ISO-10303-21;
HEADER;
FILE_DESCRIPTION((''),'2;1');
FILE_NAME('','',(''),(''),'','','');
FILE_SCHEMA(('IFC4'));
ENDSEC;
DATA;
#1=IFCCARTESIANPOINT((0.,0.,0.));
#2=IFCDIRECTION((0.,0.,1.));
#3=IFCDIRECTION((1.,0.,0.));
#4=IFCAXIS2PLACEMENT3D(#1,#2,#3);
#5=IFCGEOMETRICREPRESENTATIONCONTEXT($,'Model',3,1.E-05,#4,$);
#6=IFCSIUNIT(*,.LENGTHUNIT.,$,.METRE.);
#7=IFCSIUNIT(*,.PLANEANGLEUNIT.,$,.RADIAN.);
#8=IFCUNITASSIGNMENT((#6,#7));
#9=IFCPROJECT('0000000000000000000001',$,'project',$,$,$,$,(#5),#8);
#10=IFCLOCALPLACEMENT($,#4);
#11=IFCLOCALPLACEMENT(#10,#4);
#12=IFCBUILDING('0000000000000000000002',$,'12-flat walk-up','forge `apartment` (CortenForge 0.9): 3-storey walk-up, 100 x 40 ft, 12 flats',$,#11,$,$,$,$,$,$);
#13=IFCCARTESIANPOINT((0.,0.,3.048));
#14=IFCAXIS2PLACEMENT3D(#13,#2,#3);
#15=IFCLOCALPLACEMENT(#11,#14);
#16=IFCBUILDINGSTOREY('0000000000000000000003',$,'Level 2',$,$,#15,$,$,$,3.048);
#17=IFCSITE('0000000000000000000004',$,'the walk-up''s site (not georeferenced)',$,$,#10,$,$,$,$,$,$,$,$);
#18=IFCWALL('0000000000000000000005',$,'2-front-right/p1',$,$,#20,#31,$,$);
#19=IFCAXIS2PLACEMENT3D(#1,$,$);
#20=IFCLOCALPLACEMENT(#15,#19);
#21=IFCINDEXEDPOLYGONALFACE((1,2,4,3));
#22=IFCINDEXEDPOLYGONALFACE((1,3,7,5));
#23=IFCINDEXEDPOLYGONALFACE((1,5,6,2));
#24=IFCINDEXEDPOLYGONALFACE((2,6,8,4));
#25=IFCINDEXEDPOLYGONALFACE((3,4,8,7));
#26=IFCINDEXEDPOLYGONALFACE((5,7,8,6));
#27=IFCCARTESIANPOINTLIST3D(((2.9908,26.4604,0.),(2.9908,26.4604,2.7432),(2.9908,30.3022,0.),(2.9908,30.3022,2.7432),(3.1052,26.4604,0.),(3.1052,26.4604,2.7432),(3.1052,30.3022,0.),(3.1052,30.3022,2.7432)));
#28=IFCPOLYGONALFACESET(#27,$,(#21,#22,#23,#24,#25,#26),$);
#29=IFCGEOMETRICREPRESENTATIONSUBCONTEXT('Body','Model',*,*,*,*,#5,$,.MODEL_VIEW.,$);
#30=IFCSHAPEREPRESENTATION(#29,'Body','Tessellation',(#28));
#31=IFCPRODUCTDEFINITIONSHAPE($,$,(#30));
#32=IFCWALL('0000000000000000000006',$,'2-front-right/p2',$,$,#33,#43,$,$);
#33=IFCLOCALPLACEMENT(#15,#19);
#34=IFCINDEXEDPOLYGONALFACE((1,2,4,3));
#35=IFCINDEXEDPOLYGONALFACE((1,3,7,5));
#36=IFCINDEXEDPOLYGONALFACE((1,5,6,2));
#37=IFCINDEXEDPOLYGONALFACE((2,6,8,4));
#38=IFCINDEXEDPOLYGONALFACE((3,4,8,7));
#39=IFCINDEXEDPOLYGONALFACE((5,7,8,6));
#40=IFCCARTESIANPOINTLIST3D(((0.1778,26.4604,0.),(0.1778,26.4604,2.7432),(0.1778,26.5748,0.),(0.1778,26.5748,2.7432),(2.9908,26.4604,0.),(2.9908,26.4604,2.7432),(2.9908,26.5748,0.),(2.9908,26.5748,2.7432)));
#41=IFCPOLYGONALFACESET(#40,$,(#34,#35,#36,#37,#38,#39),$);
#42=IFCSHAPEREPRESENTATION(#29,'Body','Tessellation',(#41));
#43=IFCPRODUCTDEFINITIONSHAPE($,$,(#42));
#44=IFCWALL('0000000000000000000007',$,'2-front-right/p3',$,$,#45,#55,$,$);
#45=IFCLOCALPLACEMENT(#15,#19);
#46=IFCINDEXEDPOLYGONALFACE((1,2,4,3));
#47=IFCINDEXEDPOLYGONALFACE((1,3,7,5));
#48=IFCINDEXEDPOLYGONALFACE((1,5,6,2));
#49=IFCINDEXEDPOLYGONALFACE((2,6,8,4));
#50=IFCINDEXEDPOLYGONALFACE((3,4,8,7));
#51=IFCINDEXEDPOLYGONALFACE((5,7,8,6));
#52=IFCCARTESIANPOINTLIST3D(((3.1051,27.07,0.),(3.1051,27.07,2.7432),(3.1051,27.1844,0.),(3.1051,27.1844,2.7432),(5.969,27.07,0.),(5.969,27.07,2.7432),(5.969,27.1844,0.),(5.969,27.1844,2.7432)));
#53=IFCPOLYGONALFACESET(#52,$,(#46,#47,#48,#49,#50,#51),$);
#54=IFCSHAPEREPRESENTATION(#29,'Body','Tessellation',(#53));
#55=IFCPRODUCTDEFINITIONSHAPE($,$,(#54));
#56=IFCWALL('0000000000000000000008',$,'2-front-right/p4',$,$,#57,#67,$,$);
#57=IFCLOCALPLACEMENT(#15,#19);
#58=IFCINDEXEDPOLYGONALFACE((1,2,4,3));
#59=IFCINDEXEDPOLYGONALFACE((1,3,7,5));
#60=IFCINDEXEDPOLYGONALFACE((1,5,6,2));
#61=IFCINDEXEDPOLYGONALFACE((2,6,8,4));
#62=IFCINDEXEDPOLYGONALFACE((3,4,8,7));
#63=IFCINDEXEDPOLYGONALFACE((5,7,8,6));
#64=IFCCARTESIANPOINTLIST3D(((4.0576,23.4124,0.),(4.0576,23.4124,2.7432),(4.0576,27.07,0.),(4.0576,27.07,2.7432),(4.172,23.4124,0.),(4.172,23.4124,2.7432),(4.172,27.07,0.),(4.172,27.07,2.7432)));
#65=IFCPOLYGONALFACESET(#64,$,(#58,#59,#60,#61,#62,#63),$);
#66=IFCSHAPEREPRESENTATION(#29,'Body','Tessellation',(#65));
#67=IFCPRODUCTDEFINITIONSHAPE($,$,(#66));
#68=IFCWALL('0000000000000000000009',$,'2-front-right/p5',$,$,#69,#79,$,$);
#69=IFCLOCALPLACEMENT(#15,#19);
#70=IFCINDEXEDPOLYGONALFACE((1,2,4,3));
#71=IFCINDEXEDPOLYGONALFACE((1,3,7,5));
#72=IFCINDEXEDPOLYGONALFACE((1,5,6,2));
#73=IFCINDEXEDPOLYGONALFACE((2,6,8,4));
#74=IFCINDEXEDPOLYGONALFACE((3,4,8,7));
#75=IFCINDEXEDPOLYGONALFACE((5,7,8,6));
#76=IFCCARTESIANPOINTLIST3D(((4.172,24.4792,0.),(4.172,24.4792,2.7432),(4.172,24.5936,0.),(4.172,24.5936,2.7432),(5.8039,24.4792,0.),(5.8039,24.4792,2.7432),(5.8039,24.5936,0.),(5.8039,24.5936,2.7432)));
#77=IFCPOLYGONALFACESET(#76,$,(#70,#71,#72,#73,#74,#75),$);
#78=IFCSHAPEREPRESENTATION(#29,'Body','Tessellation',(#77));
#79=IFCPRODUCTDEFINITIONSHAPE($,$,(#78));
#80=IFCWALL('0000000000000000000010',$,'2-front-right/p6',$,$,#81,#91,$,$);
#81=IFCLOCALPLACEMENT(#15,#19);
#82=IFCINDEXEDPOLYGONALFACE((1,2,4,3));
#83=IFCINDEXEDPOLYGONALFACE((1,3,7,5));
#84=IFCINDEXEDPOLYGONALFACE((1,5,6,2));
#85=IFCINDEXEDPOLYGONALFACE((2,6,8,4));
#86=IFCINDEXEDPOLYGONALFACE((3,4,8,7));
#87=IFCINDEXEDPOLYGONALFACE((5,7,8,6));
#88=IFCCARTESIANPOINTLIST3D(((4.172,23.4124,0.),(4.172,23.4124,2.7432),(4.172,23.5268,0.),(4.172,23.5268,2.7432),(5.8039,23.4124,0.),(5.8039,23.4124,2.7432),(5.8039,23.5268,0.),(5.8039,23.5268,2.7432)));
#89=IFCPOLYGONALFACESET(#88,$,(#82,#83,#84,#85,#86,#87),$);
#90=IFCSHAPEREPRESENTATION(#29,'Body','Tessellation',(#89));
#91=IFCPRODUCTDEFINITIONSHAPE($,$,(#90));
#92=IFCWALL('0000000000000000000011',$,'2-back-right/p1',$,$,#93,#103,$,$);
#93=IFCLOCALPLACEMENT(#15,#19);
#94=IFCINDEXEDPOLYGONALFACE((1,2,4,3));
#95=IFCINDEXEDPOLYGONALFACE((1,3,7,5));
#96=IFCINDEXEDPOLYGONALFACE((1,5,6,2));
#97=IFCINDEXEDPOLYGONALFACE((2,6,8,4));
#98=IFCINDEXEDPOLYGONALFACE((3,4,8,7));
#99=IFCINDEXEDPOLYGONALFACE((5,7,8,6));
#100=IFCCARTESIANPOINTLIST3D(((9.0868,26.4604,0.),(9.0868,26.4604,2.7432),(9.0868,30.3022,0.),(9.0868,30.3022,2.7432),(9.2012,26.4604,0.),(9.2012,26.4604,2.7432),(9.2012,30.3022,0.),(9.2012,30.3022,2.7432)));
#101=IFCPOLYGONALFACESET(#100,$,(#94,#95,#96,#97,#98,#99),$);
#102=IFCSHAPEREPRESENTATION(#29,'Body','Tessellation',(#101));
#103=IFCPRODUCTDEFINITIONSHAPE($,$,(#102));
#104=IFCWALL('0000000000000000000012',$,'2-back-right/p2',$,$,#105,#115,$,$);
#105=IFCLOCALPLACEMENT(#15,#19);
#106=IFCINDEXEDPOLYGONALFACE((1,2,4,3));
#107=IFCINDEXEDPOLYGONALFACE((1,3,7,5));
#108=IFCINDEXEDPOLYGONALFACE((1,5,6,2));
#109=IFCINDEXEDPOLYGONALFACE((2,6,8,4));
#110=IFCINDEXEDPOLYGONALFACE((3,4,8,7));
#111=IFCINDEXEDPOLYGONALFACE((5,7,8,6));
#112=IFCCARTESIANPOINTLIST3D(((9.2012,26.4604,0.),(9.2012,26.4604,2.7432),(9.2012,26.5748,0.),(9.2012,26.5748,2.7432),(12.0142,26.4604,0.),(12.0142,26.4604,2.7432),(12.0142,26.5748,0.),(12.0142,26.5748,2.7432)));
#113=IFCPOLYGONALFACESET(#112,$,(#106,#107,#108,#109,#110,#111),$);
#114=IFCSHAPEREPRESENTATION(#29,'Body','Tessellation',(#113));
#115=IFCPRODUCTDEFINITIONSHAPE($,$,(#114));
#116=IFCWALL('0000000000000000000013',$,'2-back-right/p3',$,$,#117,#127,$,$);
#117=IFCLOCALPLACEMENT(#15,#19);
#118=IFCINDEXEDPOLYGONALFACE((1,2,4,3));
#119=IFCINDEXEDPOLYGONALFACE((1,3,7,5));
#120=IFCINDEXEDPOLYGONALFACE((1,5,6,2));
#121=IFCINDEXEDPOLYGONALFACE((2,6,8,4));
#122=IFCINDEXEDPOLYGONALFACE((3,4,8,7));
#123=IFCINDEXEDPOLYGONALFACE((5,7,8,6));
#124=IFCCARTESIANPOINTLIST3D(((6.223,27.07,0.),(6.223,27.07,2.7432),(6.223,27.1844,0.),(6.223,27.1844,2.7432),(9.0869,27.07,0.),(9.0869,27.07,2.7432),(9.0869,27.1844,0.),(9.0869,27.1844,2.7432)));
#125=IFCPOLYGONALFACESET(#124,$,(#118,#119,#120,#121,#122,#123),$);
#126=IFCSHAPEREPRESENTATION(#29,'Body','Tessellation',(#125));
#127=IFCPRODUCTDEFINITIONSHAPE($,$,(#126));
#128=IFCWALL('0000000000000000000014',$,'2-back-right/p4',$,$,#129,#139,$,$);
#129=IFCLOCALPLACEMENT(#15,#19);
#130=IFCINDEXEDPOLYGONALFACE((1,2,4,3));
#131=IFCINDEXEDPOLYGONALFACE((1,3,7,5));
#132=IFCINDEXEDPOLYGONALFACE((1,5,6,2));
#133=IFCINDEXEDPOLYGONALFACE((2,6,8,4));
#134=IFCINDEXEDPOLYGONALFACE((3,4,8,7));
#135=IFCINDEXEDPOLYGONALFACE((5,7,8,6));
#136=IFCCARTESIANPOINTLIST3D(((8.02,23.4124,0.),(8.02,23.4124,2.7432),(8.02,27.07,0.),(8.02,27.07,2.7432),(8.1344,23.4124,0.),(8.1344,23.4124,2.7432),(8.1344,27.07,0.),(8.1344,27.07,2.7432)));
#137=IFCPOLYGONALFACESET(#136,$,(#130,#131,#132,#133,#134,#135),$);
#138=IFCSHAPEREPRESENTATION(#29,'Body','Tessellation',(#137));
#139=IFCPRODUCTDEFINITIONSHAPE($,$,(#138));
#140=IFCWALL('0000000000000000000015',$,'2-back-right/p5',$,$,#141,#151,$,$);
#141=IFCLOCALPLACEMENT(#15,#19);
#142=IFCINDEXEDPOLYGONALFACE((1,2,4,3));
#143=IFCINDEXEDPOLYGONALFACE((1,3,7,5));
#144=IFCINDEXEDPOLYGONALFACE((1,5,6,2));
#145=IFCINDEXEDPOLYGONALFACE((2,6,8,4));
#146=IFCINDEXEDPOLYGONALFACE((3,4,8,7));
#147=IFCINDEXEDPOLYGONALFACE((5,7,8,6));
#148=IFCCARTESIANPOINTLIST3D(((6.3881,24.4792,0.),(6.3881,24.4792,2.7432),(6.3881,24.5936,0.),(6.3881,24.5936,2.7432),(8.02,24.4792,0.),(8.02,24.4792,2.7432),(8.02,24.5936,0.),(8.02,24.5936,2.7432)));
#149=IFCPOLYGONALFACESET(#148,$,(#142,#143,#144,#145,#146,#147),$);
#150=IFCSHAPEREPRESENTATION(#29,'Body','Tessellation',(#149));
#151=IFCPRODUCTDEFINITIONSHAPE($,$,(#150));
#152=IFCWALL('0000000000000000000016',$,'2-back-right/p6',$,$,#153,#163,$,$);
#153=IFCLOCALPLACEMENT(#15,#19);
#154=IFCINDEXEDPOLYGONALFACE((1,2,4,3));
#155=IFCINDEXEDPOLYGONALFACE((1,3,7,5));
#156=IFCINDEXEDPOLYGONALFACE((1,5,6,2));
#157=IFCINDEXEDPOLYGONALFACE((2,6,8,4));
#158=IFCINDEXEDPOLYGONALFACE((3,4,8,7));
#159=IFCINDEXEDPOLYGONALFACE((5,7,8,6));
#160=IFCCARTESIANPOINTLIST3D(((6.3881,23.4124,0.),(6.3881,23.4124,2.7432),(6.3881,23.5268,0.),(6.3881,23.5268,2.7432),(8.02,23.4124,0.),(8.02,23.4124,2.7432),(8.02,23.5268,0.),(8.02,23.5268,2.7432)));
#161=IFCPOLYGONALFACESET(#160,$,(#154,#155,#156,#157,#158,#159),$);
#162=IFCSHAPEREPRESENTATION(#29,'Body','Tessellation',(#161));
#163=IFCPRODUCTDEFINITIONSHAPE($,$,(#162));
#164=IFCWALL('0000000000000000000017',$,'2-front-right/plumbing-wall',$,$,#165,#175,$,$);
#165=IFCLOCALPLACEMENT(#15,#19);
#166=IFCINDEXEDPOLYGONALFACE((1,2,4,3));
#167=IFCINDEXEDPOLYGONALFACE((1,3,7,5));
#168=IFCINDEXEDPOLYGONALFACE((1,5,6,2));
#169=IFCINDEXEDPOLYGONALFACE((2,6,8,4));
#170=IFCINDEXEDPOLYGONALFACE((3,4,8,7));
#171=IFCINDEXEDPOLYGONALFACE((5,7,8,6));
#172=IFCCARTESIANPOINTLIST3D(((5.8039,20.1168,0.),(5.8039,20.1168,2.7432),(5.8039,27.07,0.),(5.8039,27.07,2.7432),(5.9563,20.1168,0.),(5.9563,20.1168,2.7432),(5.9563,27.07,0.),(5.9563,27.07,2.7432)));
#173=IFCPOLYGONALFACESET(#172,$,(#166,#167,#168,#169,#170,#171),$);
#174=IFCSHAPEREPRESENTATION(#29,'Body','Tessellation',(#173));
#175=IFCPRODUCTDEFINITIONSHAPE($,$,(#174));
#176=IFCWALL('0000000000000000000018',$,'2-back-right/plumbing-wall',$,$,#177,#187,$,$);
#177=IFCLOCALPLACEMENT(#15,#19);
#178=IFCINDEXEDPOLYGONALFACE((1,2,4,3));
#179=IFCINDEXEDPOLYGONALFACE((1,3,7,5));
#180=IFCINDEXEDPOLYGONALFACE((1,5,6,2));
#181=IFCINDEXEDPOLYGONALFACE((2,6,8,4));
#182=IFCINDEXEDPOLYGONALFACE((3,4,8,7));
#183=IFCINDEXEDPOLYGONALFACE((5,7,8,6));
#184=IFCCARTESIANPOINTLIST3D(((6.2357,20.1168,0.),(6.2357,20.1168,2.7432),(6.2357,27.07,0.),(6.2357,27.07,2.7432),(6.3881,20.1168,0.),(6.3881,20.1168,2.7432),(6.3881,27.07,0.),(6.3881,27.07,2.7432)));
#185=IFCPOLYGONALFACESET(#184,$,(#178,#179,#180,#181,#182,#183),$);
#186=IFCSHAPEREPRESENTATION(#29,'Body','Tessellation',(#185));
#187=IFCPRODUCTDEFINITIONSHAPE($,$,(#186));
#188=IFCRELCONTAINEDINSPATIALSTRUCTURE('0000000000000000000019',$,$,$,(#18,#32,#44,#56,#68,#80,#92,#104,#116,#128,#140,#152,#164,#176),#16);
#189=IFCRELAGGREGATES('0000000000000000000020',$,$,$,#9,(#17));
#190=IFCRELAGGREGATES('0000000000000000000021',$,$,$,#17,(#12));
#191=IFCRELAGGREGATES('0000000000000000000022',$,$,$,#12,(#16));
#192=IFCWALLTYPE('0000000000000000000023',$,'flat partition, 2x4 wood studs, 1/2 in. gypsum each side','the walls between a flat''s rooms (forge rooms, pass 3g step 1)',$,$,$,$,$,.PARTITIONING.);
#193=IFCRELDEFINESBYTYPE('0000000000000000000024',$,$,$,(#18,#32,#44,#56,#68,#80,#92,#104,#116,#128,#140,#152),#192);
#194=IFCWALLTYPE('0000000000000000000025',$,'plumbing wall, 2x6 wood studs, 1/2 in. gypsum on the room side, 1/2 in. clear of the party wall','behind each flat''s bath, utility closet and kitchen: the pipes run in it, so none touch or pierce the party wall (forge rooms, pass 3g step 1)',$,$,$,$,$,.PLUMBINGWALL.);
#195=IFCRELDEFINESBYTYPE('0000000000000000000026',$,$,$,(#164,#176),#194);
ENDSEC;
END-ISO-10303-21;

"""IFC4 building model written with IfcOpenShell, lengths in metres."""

from ifc_helpers import new_model, si_unit, frame, frame_2d, origin, origin_with_axes, place, context, subcontext, project, spatial, rectangle, extrude, type_object, element, save


model = new_model("IFC4")

# Units and contexts
model_context = context("Model", 3, precision=1e-05, world=origin_with_axes())
body_context = subcontext(model_context, "Body", "Model", "MODEL_VIEW")
ifc_project = project(units=[si_unit("LENGTHUNIT", "METRE"), si_unit("PLANEANGLEUNIT", "RADIAN")], contexts=[model_context])

# Site, building, storey
site_placement = place(None, origin_with_axes())
site = spatial("IfcSite", under=ifc_project, at=site_placement, Name="the walk-up's site (not georeferenced)")
building_placement = place(site_placement, origin_with_axes())
building = spatial("IfcBuilding", under=site, at=building_placement, Name="12-flat walk-up", Description="forge `apartment` (CortenForge 0.9): 3-storey walk-up, 100 x 40 ft, 12 flats")
storey_placement = place(building_placement, frame((0.0, 0.0, 3.048), z_axis=(0.0, 0.0, 1.0), x_axis=(1.0, 0.0, 0.0)))
storey = spatial("IfcBuildingStorey", under=building, at=storey_placement, Name="Level 2", Elevation=3.048)

# Walls
wall_type_1 = type_object("IfcWallType", Name="flat partition, 2x4 wood studs, 1/2 in. gypsum each side", Description="the walls between a flat's rooms (forge rooms, pass 3g step 1)", PredefinedType="PARTITIONING")
wall_1_placement = place(storey_placement, frame((2.9909, 26.4605, 0.0), z_axis=(0.0, 0.0, 1.0), x_axis=(1.0, 0.0, 0.0)))
element("IfcWall", 1, at=wall_1_placement, inside=storey, type_object=wall_type_1, Name="2-front-right/p1", context=body_context, shape_type="SweptSolid", body=[
    extrude(rectangle(XDim=0.1143, YDim=3.8417, at=frame_2d((0.0572, 1.9209))), origin(), (0.0, 0.0, 1.0), 2.7432),
])
wall_2_placement = place(storey_placement, frame((0.1778, 26.4605, 0.0), z_axis=(0.0, 0.0, 1.0), x_axis=(1.0, 0.0, 0.0)))
element("IfcWall", 2, at=wall_2_placement, inside=storey, type_object=wall_type_1, Name="2-front-right/p2", context=body_context, shape_type="SweptSolid", body=[
    extrude(rectangle(XDim=2.8131, YDim=0.1143, at=frame_2d((1.4065, 0.0572))), origin(), (0.0, 0.0, 1.0), 2.7432),
])
wall_3_placement = place(storey_placement, frame((3.1051, 27.07, 0.0), z_axis=(0.0, 0.0, 1.0), x_axis=(1.0, 0.0, 0.0)))
element("IfcWall", 3, at=wall_3_placement, inside=storey, type_object=wall_type_1, Name="2-front-right/p3", context=body_context, shape_type="SweptSolid", body=[
    extrude(rectangle(XDim=2.8639, YDim=0.1143, at=frame_2d((1.4319, 0.0572))), origin(), (0.0, 0.0, 1.0), 2.7432),
])
wall_4_placement = place(storey_placement, frame((4.0576, 23.4124, 0.0), z_axis=(0.0, 0.0, 1.0), x_axis=(1.0, 0.0, 0.0)))
element("IfcWall", 4, at=wall_4_placement, inside=storey, type_object=wall_type_1, Name="2-front-right/p4", context=body_context, shape_type="SweptSolid", body=[
    extrude(rectangle(XDim=0.1143, YDim=3.6576, at=frame_2d((0.0572, 1.8288))), origin(), (0.0, 0.0, 1.0), 2.7432),
])
for number, where, z_axis, x_axis, name in (
    (5, (4.1719, 24.4793, 0.0), (0.0, 0.0, 1.0), (1.0, 0.0, 0.0), "2-front-right/p5"),
    (6, (4.1719, 23.4124, 0.0), (0.0, 0.0, 1.0), (1.0, 0.0, 0.0), "2-front-right/p6"),
):
    element("IfcWall", number, at=place(storey_placement, frame(where, z_axis=z_axis, x_axis=x_axis)), inside=storey, type_object=wall_type_1, Name=name, context=body_context, shape_type="SweptSolid", body=[
        extrude(rectangle(XDim=1.6319, YDim=0.1143, at=frame_2d((0.816, 0.0572))), origin(), (0.0, 0.0, 1.0), 2.7432),
    ])
wall_5_placement = place(storey_placement, frame((9.0869, 26.4605, 0.0), z_axis=(0.0, 0.0, 1.0), x_axis=(1.0, 0.0, 0.0)))
element("IfcWall", 7, at=wall_5_placement, inside=storey, type_object=wall_type_1, Name="2-back-right/p1", context=body_context, shape_type="SweptSolid", body=[
    extrude(rectangle(XDim=0.1143, YDim=3.8417, at=frame_2d((0.0572, 1.9209))), origin(), (0.0, 0.0, 1.0), 2.7432),
])
wall_6_placement = place(storey_placement, frame((9.2012, 26.4605, 0.0), z_axis=(0.0, 0.0, 1.0), x_axis=(1.0, 0.0, 0.0)))
element("IfcWall", 8, at=wall_6_placement, inside=storey, type_object=wall_type_1, Name="2-back-right/p2", context=body_context, shape_type="SweptSolid", body=[
    extrude(rectangle(XDim=2.8131, YDim=0.1143, at=frame_2d((1.4065, 0.0572))), origin(), (0.0, 0.0, 1.0), 2.7432),
])
wall_7_placement = place(storey_placement, frame((6.223, 27.07, 0.0), z_axis=(0.0, 0.0, 1.0), x_axis=(1.0, 0.0, 0.0)))
element("IfcWall", 9, at=wall_7_placement, inside=storey, type_object=wall_type_1, Name="2-back-right/p3", context=body_context, shape_type="SweptSolid", body=[
    extrude(rectangle(XDim=2.8639, YDim=0.1143, at=frame_2d((1.4319, 0.0572))), origin(), (0.0, 0.0, 1.0), 2.7432),
])
wall_8_placement = place(storey_placement, frame((8.02, 23.4124, 0.0), z_axis=(0.0, 0.0, 1.0), x_axis=(1.0, 0.0, 0.0)))
element("IfcWall", 10, at=wall_8_placement, inside=storey, type_object=wall_type_1, Name="2-back-right/p4", context=body_context, shape_type="SweptSolid", body=[
    extrude(rectangle(XDim=0.1143, YDim=3.6576, at=frame_2d((0.0572, 1.8288))), origin(), (0.0, 0.0, 1.0), 2.7432),
])
for number, where, z_axis, x_axis, name in (
    (11, (6.3881, 24.4793, 0.0), (0.0, 0.0, 1.0), (1.0, 0.0, 0.0), "2-back-right/p5"),
    (12, (6.3881, 23.4124, 0.0), (0.0, 0.0, 1.0), (1.0, 0.0, 0.0), "2-back-right/p6"),
):
    element("IfcWall", number, at=place(storey_placement, frame(where, z_axis=z_axis, x_axis=x_axis)), inside=storey, type_object=wall_type_1, Name=name, context=body_context, shape_type="SweptSolid", body=[
        extrude(rectangle(XDim=1.6319, YDim=0.1143, at=frame_2d((0.816, 0.0572))), origin(), (0.0, 0.0, 1.0), 2.7432),
    ])
wall_type_2 = type_object("IfcWallType", Name="plumbing wall, 2x6 wood studs, 1/2 in. gypsum on the room side, 1/2 in. clear of the party wall", Description="behind each flat's bath, utility closet and kitchen: the pipes run in it, so none touch or pierce the party wall (forge rooms, pass 3g step 1)", PredefinedType="PLUMBINGWALL")
for number, where, z_axis, x_axis, name in (
    (13, (5.8039, 20.1168, 0.0), (0.0, 0.0, 1.0), (1.0, 0.0, 0.0), "2-front-right/plumbing-wall"),
    (14, (6.2357, 20.1168, 0.0), (0.0, 0.0, 1.0), (1.0, 0.0, 0.0), "2-back-right/plumbing-wall"),
):
    element("IfcWall", number, at=place(storey_placement, frame(where, z_axis=z_axis, x_axis=x_axis)), inside=storey, type_object=wall_type_2, Name=name, context=body_context, shape_type="SweptSolid", body=[
        extrude(rectangle(XDim=0.1524, YDim=6.9532, at=frame_2d((0.0762, 3.4766))), origin(), (0.0, 0.0, 1.0), 2.7432),
    ])

save(model, "model.ifc")
